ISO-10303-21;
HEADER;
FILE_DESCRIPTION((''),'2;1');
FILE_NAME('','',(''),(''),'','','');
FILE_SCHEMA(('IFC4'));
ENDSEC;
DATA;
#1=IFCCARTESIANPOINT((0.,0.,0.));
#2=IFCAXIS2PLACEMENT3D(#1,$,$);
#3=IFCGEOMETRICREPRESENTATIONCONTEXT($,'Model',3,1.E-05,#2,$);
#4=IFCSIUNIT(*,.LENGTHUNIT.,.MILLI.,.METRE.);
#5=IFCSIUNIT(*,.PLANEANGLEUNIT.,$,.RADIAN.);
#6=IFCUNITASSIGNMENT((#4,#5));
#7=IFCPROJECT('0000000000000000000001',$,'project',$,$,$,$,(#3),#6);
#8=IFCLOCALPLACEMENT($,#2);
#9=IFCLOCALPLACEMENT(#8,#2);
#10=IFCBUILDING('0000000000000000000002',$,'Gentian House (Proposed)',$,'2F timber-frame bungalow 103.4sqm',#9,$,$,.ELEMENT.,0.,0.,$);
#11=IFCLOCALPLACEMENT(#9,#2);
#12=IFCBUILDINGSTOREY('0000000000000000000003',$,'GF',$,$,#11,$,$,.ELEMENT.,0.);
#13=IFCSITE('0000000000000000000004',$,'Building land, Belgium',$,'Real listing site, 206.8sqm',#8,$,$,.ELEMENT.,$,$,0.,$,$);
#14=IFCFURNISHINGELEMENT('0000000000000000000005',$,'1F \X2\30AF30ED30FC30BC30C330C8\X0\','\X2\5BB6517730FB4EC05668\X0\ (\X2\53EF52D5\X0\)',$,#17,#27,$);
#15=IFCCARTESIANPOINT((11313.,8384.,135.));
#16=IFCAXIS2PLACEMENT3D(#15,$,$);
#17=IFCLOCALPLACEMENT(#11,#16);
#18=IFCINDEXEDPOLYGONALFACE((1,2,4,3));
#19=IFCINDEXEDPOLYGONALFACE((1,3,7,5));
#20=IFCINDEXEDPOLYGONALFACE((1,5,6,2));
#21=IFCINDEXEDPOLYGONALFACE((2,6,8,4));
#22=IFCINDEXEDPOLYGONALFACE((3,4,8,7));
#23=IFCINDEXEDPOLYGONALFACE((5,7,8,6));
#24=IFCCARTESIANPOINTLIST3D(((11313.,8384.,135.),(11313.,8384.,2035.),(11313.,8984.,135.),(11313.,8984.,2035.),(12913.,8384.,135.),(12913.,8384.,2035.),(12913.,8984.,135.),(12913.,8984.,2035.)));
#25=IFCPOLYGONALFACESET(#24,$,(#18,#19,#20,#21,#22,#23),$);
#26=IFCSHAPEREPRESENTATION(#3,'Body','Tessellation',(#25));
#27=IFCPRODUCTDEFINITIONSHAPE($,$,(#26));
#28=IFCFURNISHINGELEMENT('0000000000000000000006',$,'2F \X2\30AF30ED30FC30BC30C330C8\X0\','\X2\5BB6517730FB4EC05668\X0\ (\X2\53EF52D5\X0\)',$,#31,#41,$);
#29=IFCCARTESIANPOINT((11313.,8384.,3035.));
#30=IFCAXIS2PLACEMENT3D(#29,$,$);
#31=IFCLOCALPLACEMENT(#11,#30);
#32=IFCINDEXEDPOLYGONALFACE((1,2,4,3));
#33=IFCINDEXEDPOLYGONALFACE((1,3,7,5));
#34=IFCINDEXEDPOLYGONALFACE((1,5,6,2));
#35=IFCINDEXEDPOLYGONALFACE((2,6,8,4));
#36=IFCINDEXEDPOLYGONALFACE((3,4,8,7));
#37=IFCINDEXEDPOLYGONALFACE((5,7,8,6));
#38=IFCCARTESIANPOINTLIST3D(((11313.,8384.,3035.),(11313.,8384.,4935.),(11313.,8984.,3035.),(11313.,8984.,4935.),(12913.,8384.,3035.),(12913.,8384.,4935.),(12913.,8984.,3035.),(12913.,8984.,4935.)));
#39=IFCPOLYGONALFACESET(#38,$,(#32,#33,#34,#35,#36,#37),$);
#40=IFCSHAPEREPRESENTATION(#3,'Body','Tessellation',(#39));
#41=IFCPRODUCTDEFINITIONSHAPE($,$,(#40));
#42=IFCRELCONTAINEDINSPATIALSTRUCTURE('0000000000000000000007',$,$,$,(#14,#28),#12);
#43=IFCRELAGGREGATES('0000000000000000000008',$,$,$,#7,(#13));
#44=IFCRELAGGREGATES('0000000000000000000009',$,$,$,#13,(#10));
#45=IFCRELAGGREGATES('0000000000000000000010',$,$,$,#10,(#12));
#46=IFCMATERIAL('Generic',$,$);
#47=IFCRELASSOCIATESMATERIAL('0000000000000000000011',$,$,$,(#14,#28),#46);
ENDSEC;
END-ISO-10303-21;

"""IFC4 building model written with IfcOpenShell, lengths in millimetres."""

from ifc_helpers import new_model, si_unit, frame, frame_2d, origin, place, context, project, spatial, rectangle, extrude, material, element, save


model = new_model("IFC4")

# Units and contexts
model_context = context("Model", 3, precision=1e-05, world=origin())
ifc_project = project(units=[si_unit("LENGTHUNIT", "METRE", prefix="MILLI"), si_unit("PLANEANGLEUNIT", "RADIAN")], contexts=[model_context])

# Site, building, storey
site_placement = place(None, origin())
site = spatial("IfcSite", under=ifc_project, at=site_placement, Name="Building land, Belgium", ObjectType="Real listing site, 206.8sqm", CompositionType="ELEMENT", RefElevation=0.0)
building_placement = place(site_placement, origin())
building = spatial("IfcBuilding", under=site, at=building_placement, Name="Gentian House (Proposed)", ObjectType="2F timber-frame bungalow 103.4sqm", CompositionType="ELEMENT", ElevationOfRefHeight=0.0, ElevationOfTerrain=0.0)
storey_placement = place(building_placement, origin())
storey = spatial("IfcBuildingStorey", under=building, at=storey_placement, Name="GF", CompositionType="ELEMENT", Elevation=0.0)

# Shared definitions
ifc_material_1 = material(Name="Generic")

# Furnishing elements
furnishing_1_placement = place(storey_placement, frame((11313.0, 8384.0, 135.0)))
element("IfcFurnishingElement", 1, at=furnishing_1_placement, inside=storey, material=ifc_material_1, Name="1F クローゼット", Description="家具・什器 (可動)", context=model_context, shape_type="SweptSolid", body=[
    extrude(rectangle(XDim=1600.0, YDim=600.0, at=frame_2d((800.0, 300.0))), frame((11313.0, 8384.0, 135.0)), (0.0, 0.0, 1.0), 1900.0),
])
furnishing_2_placement = place(storey_placement, frame((11313.0, 8384.0, 3035.0)))
element("IfcFurnishingElement", 2, at=furnishing_2_placement, inside=storey, material=ifc_material_1, Name="2F クローゼット", Description="家具・什器 (可動)", context=model_context, shape_type="SweptSolid", body=[
    extrude(rectangle(XDim=1600.0, YDim=600.0, at=frame_2d((800.0, 300.0))), frame((11313.0, 8384.0, 3035.0)), (0.0, 0.0, 1.0), 1900.0),
])

save(model, "model.ifc")
